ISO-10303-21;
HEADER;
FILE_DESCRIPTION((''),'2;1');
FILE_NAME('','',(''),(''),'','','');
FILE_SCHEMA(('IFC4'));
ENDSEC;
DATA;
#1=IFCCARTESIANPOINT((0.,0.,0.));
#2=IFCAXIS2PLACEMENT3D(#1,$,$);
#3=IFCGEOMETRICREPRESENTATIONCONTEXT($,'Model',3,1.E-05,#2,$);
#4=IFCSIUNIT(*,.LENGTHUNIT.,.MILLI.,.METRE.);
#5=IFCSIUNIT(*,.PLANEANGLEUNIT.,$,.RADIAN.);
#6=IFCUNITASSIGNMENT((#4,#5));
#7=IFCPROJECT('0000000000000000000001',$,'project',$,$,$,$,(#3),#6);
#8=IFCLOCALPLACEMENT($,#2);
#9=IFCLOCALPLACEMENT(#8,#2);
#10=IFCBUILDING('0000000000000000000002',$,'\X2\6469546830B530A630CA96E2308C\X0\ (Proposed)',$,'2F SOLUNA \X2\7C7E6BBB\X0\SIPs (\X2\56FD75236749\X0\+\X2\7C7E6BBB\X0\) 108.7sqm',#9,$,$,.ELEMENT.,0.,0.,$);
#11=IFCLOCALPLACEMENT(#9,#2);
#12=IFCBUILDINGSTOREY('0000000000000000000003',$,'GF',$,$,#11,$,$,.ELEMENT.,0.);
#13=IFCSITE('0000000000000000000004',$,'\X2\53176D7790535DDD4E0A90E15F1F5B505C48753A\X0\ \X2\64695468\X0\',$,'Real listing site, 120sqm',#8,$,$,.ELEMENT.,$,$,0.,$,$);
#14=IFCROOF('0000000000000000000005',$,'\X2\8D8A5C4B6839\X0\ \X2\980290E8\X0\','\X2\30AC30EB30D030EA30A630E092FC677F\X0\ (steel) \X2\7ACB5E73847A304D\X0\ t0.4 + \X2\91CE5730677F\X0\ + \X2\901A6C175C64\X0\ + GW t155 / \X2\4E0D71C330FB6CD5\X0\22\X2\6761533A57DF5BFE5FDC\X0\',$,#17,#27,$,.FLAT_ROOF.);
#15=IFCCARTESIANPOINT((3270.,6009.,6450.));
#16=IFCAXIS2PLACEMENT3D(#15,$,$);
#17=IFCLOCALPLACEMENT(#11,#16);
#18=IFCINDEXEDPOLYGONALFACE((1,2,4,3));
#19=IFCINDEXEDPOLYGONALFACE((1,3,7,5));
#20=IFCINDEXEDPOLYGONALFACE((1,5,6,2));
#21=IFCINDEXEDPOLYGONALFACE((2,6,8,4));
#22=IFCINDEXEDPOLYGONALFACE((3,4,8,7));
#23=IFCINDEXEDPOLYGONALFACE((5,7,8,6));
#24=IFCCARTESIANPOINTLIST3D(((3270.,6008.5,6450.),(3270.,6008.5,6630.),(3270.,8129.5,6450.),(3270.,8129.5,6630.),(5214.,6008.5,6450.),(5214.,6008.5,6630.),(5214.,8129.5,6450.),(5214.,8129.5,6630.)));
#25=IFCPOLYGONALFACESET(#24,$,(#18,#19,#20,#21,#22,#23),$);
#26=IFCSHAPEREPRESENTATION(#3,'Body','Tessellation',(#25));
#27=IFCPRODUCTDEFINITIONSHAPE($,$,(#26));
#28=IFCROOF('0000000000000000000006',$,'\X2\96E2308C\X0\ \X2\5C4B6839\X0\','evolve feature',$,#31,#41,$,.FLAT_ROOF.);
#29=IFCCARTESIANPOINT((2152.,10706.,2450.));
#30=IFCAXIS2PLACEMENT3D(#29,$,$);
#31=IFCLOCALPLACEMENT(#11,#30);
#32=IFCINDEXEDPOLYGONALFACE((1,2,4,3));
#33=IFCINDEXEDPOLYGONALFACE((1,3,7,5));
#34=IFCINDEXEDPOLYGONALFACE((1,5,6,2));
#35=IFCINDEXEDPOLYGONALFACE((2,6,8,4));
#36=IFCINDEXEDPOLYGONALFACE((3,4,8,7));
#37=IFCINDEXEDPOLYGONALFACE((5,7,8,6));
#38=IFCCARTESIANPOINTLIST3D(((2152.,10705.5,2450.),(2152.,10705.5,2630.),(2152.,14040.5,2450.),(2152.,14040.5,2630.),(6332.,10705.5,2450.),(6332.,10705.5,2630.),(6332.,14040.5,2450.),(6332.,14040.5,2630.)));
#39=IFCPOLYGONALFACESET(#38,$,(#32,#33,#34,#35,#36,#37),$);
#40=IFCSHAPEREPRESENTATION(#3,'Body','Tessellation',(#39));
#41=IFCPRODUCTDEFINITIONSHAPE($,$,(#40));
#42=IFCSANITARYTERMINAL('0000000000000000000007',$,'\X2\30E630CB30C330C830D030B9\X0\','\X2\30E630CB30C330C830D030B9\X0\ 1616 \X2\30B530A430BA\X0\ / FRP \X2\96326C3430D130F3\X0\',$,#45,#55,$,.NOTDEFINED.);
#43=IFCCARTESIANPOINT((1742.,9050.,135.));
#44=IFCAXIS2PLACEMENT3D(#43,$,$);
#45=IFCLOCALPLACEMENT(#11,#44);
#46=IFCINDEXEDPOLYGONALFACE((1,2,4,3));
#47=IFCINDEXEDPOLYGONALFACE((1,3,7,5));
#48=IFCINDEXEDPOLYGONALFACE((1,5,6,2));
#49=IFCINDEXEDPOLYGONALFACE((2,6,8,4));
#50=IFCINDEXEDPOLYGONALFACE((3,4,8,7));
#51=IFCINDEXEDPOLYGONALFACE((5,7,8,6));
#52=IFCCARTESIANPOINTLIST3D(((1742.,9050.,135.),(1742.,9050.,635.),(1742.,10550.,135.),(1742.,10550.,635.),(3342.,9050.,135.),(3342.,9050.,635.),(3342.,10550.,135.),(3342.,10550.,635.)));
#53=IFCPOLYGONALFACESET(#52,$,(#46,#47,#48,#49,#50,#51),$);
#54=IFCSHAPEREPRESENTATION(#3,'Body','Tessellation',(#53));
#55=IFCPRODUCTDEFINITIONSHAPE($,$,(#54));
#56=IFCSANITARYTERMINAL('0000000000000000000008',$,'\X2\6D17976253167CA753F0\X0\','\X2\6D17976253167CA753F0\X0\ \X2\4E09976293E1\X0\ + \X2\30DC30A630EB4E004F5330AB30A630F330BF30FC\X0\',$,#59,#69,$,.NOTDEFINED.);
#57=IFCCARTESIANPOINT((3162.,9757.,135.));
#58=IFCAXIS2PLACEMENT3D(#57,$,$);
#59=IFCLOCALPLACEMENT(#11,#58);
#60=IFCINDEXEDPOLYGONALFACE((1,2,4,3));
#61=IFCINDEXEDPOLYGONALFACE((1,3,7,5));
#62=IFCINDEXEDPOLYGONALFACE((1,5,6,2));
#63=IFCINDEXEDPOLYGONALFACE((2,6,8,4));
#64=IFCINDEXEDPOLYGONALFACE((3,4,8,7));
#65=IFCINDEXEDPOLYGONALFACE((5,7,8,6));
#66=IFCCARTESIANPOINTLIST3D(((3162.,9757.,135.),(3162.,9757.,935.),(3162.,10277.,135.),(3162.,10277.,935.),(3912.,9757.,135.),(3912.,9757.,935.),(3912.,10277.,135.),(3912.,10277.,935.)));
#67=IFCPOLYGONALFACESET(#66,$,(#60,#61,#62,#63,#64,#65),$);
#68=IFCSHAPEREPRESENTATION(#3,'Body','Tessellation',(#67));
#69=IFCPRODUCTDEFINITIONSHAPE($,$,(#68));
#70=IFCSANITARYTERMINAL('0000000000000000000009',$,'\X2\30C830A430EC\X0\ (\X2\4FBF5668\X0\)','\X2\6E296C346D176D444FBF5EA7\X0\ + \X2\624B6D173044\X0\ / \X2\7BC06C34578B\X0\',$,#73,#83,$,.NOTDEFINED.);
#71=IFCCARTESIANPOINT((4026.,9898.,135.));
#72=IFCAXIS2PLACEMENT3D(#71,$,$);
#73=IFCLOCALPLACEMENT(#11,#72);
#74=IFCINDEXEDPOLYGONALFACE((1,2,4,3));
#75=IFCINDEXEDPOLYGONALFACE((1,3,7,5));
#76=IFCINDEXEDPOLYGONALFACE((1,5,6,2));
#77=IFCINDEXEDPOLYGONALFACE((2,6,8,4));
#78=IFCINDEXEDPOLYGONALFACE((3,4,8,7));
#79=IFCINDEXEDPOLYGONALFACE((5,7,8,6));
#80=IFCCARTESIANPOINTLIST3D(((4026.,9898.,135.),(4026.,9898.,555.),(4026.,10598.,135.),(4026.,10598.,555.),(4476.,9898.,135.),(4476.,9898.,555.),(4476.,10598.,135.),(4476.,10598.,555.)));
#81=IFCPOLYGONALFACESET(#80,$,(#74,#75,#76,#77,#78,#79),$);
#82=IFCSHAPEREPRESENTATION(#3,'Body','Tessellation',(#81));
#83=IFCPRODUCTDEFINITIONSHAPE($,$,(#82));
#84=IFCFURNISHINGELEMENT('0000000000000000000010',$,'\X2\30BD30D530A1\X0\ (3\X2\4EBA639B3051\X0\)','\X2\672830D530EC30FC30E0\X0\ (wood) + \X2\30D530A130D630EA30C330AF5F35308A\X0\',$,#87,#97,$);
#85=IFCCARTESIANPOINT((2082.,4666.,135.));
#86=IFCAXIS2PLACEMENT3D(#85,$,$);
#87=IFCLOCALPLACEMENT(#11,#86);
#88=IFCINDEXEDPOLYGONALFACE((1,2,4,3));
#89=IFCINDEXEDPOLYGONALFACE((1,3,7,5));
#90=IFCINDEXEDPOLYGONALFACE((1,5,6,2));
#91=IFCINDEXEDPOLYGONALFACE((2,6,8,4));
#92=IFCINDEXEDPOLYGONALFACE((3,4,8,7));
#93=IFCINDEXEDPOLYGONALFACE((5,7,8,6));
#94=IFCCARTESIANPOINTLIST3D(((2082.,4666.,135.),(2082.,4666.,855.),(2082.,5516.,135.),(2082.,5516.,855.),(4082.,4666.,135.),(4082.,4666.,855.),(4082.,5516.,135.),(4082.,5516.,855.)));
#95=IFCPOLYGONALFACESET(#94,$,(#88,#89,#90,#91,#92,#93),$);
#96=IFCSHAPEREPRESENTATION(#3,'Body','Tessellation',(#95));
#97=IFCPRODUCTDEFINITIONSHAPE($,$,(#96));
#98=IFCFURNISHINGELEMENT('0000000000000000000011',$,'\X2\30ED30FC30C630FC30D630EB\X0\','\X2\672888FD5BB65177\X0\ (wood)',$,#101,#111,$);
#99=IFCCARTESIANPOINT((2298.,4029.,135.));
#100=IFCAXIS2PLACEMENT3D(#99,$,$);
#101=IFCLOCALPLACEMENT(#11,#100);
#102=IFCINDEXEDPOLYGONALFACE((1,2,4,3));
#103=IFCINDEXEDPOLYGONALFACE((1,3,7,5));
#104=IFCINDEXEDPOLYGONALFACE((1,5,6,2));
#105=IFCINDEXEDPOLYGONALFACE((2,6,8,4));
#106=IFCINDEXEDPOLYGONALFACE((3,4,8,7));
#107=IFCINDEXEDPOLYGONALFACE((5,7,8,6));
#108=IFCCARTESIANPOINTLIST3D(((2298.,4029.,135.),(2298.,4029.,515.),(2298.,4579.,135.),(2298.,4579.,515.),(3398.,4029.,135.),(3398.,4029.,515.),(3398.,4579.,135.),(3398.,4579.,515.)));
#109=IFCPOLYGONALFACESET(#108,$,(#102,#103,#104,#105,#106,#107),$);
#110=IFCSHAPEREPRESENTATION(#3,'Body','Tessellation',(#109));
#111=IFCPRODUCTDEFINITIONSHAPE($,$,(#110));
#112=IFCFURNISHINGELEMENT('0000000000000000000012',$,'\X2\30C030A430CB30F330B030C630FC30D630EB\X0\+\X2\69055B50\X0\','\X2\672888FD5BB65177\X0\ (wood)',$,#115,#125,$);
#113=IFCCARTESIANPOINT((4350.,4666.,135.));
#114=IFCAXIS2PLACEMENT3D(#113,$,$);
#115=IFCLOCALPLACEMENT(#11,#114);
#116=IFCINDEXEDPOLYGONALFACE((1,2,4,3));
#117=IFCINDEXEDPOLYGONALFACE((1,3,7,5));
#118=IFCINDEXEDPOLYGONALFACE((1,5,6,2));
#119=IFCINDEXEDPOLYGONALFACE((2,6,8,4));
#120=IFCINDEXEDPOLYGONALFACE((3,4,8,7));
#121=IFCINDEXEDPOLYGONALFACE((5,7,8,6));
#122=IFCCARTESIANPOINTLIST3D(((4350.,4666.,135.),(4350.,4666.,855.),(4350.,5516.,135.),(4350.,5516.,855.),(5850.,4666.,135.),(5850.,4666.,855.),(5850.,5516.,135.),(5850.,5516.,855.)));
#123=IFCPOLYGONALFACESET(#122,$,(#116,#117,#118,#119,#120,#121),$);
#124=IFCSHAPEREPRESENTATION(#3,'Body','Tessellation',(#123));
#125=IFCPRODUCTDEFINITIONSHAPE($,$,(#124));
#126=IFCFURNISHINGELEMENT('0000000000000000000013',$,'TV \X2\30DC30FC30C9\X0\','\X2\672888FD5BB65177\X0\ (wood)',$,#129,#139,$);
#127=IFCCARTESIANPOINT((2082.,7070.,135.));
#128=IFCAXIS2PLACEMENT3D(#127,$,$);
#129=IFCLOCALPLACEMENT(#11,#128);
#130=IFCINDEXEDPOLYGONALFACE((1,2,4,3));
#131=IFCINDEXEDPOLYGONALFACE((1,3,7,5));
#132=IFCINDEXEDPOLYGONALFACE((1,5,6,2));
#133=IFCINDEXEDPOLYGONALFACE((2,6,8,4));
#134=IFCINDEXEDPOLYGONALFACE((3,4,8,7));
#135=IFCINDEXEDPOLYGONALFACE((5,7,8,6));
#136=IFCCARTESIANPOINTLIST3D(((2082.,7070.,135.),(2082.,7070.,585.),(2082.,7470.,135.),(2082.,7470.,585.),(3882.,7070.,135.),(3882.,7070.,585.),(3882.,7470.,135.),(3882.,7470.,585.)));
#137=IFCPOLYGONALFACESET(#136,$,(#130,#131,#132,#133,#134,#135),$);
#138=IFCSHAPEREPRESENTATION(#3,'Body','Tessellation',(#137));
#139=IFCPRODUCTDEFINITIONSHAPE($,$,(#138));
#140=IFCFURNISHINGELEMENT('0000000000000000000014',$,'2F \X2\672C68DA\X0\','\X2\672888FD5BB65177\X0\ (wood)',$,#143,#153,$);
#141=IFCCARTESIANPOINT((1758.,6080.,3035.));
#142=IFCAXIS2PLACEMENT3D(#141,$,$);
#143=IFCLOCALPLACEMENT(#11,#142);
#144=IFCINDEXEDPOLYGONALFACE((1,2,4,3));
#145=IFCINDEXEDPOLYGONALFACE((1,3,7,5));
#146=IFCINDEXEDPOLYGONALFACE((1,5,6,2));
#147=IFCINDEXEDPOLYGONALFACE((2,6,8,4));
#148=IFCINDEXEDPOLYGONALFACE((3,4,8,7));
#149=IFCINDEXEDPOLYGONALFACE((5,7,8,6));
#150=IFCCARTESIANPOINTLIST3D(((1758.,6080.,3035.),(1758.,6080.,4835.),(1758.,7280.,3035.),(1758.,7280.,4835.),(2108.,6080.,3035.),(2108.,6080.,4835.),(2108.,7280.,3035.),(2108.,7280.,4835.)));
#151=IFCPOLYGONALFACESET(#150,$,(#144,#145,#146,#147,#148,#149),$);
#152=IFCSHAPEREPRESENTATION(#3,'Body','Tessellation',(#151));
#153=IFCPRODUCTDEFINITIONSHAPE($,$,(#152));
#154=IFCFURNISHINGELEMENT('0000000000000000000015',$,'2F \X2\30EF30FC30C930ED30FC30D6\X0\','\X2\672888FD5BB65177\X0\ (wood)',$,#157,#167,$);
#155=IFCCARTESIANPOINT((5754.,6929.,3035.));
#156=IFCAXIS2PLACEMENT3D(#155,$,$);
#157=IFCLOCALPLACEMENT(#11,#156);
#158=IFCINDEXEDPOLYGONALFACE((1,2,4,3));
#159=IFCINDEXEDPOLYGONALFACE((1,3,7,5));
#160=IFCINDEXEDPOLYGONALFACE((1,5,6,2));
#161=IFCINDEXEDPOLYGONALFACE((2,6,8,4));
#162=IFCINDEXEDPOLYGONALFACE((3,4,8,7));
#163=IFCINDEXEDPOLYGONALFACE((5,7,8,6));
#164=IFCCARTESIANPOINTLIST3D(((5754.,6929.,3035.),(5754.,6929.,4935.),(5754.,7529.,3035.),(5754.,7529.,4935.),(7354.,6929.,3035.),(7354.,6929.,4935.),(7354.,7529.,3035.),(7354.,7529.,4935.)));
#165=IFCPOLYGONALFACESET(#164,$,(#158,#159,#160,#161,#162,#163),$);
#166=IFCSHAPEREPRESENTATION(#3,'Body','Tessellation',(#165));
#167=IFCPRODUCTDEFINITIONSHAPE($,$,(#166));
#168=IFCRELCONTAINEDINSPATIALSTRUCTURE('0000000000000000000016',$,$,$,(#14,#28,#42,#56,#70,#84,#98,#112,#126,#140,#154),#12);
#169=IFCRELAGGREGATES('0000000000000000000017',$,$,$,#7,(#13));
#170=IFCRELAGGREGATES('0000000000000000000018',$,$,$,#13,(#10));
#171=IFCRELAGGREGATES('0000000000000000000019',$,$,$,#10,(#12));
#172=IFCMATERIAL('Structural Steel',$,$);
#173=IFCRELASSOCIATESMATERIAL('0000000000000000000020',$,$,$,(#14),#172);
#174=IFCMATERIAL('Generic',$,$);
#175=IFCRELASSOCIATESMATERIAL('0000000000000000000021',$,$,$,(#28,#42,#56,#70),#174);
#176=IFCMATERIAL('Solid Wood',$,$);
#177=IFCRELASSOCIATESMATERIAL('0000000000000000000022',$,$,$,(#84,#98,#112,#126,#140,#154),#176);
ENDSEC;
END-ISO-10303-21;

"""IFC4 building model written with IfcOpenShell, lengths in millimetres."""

from ifc_helpers import new_model, si_unit, frame, frame_2d, origin, place, context, project, spatial, rectangle, extrude, material, element, save


model = new_model("IFC4")

# Units and contexts
model_context = context("Model", 3, precision=1e-05, world=origin())
ifc_project = project(units=[si_unit("LENGTHUNIT", "METRE", prefix="MILLI"), si_unit("PLANEANGLEUNIT", "RADIAN")], contexts=[model_context])

# Site, building, storey
site_placement = place(None, origin())
site = spatial("IfcSite", under=ifc_project, at=site_placement, Name="北海道川上郡弟子屈町 摩周", ObjectType="Real listing site, 120sqm", CompositionType="ELEMENT", RefElevation=0.0)
building_placement = place(site_placement, origin())
building = spatial("IfcBuilding", under=site, at=building_placement, Name="摩周サウナ離れ (Proposed)", ObjectType="2F SOLUNA 籾殻SIPs (国産杉+籾殻) 108.7sqm", CompositionType="ELEMENT", ElevationOfRefHeight=0.0, ElevationOfTerrain=0.0)
storey_placement = place(building_placement, origin())
storey = spatial("IfcBuildingStorey", under=building, at=storey_placement, Name="GF", CompositionType="ELEMENT", Elevation=0.0)

# Shared definitions
ifc_material_1 = material(Name="Generic")

# Shared definitions
ifc_material_2 = material(Name="Solid Wood")

# Roofs
ifc_material_3 = material(Name="Structural Steel")
roof_1_placement = place(storey_placement, frame((3270.0, 6009.0, 6450.0)))
element("IfcRoof", 1, at=roof_1_placement, inside=storey, material=ifc_material_3, Name="越屋根 頂部", Description="ガルバリウム鋼板 (steel) 立平葺き t0.4 + 野地板 + 通気層 + GW t155 / 不燃・法22条区域対応", PredefinedType="FLAT_ROOF", context=model_context, shape_type="SweptSolid", body=[
    extrude(rectangle(XDim=1944.0, YDim=2121.0, at=frame_2d((972.0, 1060.0))), frame((3270.0, 6009.0, 6450.0)), (0.0, 0.0, 1.0), 180.0),
])
roof_2_placement = place(storey_placement, frame((2152.0, 10706.0, 2450.0)))
element("IfcRoof", 2, at=roof_2_placement, inside=storey, material=ifc_material_1, Name="離れ 屋根", Description="evolve feature", PredefinedType="FLAT_ROOF", context=model_context, shape_type="SweptSolid", body=[
    extrude(rectangle(XDim=4180.0, YDim=3335.0, at=frame_2d((2090.0, 1667.0))), frame((2152.0, 10706.0, 2450.0)), (0.0, 0.0, 1.0), 180.0),
])

# Sanitary terminals
sanitary_terminal_1_placement = place(storey_placement, frame((1742.0, 9050.0, 135.0)))
element("IfcSanitaryTerminal", 3, at=sanitary_terminal_1_placement, inside=storey, material=ifc_material_1, Name="ユニットバス", Description="ユニットバス 1616 サイズ / FRP 防水パン", PredefinedType="NOTDEFINED", context=model_context, shape_type="SweptSolid", body=[
    extrude(rectangle(XDim=1600.0, YDim=1500.0, at=frame_2d((800.0, 750.0))), frame((1742.0, 9050.0, 135.0)), (0.0, 0.0, 1.0), 500.0),
])
sanitary_terminal_2_placement = place(storey_placement, frame((3162.0, 9757.0, 135.0)))
element("IfcSanitaryTerminal", 4, at=sanitary_terminal_2_placement, inside=storey, material=ifc_material_1, Name="洗面化粧台", Description="洗面化粧台 三面鏡 + ボウル一体カウンター", PredefinedType="NOTDEFINED", context=model_context, shape_type="SweptSolid", body=[
    extrude(rectangle(XDim=750.0, YDim=520.0, at=frame_2d((375.0, 260.0))), frame((3162.0, 9757.0, 135.0)), (0.0, 0.0, 1.0), 800.0),
])
sanitary_terminal_3_placement = place(storey_placement, frame((4026.0, 9898.0, 135.0)))
element("IfcSanitaryTerminal", 5, at=sanitary_terminal_3_placement, inside=storey, material=ifc_material_1, Name="トイレ (便器)", Description="温水洗浄便座 + 手洗い / 節水型", PredefinedType="NOTDEFINED", context=model_context, shape_type="SweptSolid", body=[
    extrude(rectangle(XDim=450.0, YDim=700.0, at=frame_2d((225.0, 350.0))), frame((4026.0, 9898.0, 135.0)), (0.0, 0.0, 1.0), 420.0),
])

# Furnishing elements
furnishing_1_placement = place(storey_placement, frame((2082.0, 4666.0, 135.0)))
element("IfcFurnishingElement", 6, at=furnishing_1_placement, inside=storey, material=ifc_material_2, Name="ソファ (3人掛け)", Description="木フレーム (wood) + ファブリック張り", context=model_context, shape_type="SweptSolid", body=[
    extrude(rectangle(XDim=2000.0, YDim=850.0, at=frame_2d((1000.0, 425.0))), frame((2082.0, 4666.0, 135.0)), (0.0, 0.0, 1.0), 720.0),
])
furnishing_2_placement = place(storey_placement, frame((2298.0, 4029.0, 135.0)))
element("IfcFurnishingElement", 7, at=furnishing_2_placement, inside=storey, material=ifc_material_2, Name="ローテーブル", Description="木製家具 (wood)", context=model_context, shape_type="SweptSolid", body=[
    extrude(rectangle(XDim=1100.0, YDim=550.0, at=frame_2d((550.0, 275.0))), frame((2298.0, 4029.0, 135.0)), (0.0, 0.0, 1.0), 380.0),
])
furnishing_3_placement = place(storey_placement, frame((4350.0, 4666.0, 135.0)))
element("IfcFurnishingElement", 8, at=furnishing_3_placement, inside=storey, material=ifc_material_2, Name="ダイニングテーブル+椅子", Description="木製家具 (wood)", context=model_context, shape_type="SweptSolid", body=[
    extrude(rectangle(XDim=1500.0, YDim=850.0, at=frame_2d((750.0, 425.0))), frame((4350.0, 4666.0, 135.0)), (0.0, 0.0, 1.0), 720.0),
])
furnishing_4_placement = place(storey_placement, frame((2082.0, 7070.0, 135.0)))
element("IfcFurnishingElement", 9, at=furnishing_4_placement, inside=storey, material=ifc_material_2, Name="TV ボード", Description="木製家具 (wood)", context=model_context, shape_type="SweptSolid", body=[
    extrude(rectangle(XDim=1800.0, YDim=400.0, at=frame_2d((900.0, 200.0))), frame((2082.0, 7070.0, 135.0)), (0.0, 0.0, 1.0), 450.0),
])
furnishing_5_placement = place(storey_placement, frame((1758.0, 6080.0, 3035.0)))
element("IfcFurnishingElement", 10, at=furnishing_5_placement, inside=storey, material=ifc_material_2, Name="2F 本棚", Description="木製家具 (wood)", context=model_context, shape_type="SweptSolid", body=[
    extrude(rectangle(XDim=350.0, YDim=1200.0, at=frame_2d((175.0, 600.0))), frame((1758.0, 6080.0, 3035.0)), (0.0, 0.0, 1.0), 1800.0),
])
furnishing_6_placement = place(storey_placement, frame((5754.0, 6929.0, 3035.0)))
element("IfcFurnishingElement", 11, at=furnishing_6_placement, inside=storey, material=ifc_material_2, Name="2F ワードローブ", Description="木製家具 (wood)", context=model_context, shape_type="SweptSolid", body=[
    extrude(rectangle(XDim=1600.0, YDim=600.0, at=frame_2d((800.0, 300.0))), frame((5754.0, 6929.0, 3035.0)), (0.0, 0.0, 1.0), 1900.0),
])

save(model, "model.ifc")
